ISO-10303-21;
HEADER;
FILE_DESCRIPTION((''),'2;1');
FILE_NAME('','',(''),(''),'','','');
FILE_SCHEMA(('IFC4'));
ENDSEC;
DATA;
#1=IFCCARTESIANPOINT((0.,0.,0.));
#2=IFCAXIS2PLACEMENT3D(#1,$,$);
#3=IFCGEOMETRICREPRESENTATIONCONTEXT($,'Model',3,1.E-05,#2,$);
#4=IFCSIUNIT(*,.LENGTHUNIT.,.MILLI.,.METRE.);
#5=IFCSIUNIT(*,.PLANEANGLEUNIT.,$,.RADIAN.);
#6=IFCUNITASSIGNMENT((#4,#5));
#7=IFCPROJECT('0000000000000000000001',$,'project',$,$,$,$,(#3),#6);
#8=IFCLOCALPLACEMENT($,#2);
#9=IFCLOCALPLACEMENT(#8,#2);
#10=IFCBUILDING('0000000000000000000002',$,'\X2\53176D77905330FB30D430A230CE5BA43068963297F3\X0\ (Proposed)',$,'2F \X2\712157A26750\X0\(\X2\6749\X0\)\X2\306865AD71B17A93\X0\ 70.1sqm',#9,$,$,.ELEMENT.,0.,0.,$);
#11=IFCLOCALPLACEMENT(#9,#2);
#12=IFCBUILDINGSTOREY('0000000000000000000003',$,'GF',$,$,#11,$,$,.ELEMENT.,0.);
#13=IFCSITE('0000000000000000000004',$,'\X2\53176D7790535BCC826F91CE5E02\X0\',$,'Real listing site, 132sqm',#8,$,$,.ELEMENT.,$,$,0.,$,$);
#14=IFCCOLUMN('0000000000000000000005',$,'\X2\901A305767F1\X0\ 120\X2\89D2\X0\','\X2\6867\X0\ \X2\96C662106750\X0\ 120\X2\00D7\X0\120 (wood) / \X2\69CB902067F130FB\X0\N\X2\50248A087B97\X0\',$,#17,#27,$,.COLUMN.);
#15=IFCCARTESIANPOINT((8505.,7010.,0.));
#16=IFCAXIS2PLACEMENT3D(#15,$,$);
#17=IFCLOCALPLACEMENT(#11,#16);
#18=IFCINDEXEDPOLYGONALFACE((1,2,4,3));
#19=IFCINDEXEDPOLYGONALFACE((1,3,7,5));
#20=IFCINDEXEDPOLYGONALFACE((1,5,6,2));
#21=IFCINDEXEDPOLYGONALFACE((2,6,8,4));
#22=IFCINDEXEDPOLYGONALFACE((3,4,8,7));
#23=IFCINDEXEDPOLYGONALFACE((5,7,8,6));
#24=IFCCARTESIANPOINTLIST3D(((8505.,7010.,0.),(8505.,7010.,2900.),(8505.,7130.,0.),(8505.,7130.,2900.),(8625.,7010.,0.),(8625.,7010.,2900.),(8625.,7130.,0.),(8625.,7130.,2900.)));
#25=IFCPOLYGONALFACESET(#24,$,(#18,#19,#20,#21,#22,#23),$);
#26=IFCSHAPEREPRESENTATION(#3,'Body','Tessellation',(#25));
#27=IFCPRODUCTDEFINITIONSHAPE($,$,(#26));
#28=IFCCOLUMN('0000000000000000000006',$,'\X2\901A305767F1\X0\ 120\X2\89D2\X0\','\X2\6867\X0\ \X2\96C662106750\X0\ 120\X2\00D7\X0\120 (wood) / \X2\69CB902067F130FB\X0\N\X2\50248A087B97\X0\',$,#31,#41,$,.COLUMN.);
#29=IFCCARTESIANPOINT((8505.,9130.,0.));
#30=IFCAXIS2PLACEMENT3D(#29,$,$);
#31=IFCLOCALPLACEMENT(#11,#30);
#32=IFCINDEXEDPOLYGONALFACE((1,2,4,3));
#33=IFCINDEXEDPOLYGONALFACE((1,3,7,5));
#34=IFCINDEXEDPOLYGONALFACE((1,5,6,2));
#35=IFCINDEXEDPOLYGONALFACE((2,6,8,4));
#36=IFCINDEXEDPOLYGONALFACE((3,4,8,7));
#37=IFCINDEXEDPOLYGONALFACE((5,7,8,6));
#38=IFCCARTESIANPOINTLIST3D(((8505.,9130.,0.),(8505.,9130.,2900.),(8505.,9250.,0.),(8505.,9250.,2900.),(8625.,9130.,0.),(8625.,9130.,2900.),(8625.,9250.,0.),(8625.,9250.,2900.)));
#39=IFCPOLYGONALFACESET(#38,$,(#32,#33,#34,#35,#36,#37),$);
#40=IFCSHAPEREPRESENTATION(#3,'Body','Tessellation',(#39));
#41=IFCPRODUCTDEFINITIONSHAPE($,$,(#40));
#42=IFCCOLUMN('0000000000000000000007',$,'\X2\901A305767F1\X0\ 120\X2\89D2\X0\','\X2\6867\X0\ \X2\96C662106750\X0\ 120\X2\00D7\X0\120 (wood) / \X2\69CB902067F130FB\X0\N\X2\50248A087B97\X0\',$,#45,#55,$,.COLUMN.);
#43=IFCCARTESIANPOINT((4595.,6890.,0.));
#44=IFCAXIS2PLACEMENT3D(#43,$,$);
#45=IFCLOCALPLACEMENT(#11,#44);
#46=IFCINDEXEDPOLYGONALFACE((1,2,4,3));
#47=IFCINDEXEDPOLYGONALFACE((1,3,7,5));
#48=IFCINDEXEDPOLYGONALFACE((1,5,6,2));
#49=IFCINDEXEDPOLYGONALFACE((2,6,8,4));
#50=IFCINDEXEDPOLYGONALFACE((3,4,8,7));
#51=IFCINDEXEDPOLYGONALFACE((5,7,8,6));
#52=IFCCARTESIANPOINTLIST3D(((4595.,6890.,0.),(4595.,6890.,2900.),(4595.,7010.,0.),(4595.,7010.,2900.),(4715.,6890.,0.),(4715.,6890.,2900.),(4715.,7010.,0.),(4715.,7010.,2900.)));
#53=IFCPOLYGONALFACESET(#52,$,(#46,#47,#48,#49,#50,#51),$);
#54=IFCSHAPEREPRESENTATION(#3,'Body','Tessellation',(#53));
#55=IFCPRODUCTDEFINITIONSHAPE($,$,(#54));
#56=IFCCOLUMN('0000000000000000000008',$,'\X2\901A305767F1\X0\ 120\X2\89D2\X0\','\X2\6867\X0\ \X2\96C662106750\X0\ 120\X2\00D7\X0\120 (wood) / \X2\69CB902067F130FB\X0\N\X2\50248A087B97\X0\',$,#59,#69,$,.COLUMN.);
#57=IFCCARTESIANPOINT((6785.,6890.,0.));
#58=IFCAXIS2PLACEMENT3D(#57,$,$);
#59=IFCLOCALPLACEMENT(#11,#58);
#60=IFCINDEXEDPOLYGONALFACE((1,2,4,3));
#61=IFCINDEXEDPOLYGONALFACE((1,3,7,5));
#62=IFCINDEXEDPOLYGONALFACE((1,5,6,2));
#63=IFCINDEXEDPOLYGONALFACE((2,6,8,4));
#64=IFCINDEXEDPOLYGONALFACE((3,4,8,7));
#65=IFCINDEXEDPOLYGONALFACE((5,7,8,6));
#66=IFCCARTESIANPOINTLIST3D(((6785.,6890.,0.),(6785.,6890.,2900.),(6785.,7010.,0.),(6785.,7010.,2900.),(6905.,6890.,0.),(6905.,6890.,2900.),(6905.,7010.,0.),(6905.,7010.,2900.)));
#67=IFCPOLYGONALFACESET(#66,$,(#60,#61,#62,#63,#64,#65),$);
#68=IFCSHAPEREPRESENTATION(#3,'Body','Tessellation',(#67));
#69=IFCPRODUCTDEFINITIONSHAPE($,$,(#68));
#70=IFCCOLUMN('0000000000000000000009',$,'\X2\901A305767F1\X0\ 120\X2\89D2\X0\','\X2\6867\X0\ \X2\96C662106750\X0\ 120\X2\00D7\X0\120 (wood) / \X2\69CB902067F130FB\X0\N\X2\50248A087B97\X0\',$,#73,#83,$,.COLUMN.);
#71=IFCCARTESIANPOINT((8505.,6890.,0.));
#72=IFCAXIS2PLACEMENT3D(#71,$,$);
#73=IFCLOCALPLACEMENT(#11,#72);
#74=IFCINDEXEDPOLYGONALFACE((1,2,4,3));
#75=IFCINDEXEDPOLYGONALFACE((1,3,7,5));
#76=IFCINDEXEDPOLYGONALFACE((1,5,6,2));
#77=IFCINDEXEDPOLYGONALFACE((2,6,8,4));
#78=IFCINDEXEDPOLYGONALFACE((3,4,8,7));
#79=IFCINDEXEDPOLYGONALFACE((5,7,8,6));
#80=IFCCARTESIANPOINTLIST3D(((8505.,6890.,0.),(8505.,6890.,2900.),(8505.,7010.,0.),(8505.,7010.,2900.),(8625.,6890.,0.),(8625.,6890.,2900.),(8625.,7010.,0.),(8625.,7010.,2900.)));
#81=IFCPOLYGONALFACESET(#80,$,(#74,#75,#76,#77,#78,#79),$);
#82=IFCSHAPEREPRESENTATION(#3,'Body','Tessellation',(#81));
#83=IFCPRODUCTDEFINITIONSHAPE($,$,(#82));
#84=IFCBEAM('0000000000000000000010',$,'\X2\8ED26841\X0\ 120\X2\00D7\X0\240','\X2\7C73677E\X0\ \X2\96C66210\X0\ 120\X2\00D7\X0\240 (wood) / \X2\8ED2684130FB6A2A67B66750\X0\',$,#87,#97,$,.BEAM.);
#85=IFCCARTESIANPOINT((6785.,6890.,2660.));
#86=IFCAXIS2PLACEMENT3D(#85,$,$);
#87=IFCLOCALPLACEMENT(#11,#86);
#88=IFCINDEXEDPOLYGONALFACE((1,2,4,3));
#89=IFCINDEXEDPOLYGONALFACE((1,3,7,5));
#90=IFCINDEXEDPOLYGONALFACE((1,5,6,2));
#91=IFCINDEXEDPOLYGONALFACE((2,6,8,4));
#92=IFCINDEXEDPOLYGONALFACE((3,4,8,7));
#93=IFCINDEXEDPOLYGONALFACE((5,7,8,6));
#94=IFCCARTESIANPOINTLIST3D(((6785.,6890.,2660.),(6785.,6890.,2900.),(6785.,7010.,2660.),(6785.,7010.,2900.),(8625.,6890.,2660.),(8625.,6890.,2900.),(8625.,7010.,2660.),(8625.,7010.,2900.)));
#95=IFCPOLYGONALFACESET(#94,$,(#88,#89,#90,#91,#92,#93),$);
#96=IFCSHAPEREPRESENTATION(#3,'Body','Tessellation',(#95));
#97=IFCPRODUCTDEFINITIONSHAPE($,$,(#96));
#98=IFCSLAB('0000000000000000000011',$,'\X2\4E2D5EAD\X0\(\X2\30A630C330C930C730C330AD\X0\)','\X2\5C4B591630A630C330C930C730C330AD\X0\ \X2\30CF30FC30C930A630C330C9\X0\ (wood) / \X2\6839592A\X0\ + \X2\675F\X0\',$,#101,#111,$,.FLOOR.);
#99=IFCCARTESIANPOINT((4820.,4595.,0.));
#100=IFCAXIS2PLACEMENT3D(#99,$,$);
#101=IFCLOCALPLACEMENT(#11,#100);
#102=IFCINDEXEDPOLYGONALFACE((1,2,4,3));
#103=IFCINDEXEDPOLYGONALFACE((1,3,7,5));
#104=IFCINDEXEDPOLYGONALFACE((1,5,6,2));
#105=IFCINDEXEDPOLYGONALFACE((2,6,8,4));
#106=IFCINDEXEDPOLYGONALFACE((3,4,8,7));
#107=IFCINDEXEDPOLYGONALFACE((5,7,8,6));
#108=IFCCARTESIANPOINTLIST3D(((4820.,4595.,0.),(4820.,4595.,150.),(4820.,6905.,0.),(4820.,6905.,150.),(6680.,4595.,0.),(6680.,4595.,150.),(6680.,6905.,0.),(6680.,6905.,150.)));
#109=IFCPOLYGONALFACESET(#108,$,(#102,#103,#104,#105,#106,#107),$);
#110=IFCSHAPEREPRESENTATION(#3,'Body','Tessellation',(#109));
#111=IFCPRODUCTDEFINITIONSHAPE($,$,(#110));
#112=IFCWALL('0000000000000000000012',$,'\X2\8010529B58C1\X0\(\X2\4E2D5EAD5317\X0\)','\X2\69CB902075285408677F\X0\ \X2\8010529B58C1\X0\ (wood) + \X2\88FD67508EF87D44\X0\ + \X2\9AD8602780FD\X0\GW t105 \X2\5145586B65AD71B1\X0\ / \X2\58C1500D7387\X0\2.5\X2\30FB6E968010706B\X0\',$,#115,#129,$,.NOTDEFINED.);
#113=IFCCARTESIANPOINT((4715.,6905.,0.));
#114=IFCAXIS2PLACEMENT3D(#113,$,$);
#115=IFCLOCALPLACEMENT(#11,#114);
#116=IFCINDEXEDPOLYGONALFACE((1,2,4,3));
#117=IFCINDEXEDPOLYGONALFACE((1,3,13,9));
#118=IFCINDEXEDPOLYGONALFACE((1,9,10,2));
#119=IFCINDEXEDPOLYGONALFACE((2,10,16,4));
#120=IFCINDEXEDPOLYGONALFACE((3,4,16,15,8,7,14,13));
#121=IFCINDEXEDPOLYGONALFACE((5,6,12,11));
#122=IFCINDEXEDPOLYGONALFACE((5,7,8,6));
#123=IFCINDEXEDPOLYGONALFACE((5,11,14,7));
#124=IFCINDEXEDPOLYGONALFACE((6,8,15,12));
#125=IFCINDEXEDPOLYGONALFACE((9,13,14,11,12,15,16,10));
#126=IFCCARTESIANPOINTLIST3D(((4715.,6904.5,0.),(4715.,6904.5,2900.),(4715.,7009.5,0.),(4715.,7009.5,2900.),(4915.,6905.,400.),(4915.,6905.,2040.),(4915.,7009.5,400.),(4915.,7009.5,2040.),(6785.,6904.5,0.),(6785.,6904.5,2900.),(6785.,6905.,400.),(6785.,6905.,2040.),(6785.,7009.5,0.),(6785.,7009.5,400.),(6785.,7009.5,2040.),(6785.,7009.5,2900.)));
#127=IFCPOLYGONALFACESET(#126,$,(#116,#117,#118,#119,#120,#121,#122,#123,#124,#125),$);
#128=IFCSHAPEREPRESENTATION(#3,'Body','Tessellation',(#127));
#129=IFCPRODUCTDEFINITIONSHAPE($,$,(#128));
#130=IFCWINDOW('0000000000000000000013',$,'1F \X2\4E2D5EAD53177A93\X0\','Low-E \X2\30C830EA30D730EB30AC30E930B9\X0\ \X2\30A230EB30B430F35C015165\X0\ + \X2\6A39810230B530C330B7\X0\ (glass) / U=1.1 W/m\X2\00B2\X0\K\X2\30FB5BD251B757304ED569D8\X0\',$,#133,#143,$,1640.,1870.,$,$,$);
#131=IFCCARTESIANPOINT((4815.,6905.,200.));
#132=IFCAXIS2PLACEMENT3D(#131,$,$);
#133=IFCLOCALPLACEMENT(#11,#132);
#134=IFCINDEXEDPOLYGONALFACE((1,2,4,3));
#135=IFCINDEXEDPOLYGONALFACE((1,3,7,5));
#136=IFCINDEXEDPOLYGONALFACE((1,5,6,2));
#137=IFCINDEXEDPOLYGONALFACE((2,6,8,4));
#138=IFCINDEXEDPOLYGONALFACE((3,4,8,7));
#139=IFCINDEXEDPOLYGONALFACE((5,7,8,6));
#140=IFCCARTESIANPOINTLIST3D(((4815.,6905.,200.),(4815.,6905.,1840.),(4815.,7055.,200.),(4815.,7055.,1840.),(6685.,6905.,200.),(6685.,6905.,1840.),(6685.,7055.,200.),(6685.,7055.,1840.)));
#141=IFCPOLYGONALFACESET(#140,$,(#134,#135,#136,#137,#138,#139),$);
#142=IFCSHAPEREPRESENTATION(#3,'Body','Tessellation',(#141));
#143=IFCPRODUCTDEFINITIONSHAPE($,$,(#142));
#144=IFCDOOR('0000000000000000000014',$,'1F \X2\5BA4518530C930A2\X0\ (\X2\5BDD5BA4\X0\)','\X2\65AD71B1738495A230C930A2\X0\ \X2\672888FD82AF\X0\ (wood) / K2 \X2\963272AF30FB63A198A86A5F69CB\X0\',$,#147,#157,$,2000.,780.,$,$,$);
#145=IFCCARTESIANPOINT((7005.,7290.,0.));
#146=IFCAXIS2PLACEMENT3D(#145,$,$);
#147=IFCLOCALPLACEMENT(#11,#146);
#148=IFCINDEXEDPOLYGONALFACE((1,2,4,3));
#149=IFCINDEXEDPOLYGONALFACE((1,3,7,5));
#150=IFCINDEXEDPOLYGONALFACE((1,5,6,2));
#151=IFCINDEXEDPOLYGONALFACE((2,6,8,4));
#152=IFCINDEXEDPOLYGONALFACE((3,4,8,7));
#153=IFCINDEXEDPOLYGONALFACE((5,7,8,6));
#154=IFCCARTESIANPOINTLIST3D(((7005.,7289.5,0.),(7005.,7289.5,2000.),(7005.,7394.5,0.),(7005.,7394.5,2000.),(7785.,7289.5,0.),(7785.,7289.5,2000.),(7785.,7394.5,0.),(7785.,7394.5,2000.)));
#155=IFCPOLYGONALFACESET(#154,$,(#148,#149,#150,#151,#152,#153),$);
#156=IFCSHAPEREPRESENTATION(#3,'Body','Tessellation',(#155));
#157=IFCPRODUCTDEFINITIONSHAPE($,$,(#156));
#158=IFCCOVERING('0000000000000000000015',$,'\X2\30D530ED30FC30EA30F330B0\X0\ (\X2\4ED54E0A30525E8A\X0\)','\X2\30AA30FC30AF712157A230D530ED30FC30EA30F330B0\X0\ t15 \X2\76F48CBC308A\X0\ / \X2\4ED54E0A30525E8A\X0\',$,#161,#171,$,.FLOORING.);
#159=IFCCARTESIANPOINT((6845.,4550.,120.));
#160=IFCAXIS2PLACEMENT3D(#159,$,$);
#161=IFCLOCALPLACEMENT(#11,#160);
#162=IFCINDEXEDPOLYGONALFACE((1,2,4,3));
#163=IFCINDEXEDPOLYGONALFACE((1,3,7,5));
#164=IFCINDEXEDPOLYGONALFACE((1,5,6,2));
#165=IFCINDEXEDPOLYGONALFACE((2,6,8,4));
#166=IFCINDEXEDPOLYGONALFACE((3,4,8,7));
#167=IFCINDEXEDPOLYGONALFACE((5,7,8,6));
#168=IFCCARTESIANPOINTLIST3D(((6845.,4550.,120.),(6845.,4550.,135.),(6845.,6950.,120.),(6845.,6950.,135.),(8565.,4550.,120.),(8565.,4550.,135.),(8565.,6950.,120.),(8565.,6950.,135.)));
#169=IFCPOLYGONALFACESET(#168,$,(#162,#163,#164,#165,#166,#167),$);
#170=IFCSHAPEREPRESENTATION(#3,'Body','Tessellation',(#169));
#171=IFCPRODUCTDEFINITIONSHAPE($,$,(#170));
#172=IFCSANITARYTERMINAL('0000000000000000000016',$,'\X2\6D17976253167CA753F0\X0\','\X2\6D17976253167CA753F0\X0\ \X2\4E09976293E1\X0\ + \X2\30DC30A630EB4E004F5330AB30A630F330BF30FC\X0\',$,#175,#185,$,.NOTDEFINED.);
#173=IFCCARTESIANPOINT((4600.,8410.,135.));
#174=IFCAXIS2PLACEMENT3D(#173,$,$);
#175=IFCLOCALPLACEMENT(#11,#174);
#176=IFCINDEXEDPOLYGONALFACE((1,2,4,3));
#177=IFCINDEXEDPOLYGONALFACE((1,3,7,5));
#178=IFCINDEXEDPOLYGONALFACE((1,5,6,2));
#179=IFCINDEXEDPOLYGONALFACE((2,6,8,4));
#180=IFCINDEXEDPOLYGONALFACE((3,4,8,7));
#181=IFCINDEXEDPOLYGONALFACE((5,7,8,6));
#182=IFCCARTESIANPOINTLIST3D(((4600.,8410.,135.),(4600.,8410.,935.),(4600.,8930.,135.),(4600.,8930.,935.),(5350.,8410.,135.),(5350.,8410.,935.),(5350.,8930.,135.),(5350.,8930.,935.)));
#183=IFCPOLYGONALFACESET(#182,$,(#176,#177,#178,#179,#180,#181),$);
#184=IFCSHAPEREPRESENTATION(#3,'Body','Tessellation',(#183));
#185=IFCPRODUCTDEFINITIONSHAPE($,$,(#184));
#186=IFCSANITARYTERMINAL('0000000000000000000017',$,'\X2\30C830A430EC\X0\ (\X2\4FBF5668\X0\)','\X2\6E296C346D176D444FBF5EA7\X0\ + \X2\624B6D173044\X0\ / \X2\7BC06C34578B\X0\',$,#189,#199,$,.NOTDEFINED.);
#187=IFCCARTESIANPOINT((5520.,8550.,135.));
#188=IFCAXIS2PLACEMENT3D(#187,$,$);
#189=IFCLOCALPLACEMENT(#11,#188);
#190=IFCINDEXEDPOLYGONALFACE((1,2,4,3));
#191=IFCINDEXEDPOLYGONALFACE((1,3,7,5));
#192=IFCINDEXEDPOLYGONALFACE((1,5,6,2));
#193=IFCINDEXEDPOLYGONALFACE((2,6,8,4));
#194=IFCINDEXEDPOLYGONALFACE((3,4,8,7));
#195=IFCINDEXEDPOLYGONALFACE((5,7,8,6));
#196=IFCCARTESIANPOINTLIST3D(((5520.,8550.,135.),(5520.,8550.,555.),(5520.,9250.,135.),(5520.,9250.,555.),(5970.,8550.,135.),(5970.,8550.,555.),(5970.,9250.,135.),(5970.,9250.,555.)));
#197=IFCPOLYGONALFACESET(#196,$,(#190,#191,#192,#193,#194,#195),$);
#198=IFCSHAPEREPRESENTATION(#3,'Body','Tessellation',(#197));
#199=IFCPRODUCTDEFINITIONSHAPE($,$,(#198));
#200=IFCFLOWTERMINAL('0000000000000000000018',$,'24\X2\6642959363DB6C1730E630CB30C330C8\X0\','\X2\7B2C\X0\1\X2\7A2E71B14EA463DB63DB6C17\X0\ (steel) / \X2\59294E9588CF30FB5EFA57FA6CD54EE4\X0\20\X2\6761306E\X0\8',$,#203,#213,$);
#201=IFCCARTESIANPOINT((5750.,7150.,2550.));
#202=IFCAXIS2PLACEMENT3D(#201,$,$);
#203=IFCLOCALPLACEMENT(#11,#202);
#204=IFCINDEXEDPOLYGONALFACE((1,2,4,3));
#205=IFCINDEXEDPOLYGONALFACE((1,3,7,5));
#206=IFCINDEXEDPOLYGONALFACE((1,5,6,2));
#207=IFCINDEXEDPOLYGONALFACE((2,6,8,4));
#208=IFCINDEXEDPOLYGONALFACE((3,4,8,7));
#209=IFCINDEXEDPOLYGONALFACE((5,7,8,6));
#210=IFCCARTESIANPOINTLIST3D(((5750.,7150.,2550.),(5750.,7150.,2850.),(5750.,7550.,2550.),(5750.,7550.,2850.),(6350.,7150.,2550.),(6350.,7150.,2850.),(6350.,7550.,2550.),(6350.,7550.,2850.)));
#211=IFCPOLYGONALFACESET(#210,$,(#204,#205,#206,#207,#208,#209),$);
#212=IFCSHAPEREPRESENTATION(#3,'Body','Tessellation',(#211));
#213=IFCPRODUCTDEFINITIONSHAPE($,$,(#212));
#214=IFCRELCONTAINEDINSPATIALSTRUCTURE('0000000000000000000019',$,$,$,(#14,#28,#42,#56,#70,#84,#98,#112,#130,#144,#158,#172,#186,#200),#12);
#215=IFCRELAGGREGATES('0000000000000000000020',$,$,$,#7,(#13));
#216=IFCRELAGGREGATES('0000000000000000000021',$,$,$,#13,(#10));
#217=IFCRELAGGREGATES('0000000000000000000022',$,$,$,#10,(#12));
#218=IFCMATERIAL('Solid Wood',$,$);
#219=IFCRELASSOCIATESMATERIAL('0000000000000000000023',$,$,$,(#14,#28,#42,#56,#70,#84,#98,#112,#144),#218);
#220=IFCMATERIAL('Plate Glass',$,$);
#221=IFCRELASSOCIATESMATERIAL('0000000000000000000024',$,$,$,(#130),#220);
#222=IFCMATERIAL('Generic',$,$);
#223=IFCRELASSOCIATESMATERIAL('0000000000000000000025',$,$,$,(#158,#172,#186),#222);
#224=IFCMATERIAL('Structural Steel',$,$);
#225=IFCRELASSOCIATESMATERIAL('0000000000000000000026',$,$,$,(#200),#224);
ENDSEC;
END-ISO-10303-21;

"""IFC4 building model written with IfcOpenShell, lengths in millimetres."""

from ifc_helpers import new_model, si_unit, frame, frame_2d, origin, place, context, project, spatial, rectangle, extrude, material, element, fill, save


model = new_model("IFC4")

# Units and contexts
model_context = context("Model", 3, precision=1e-05, world=origin())
ifc_project = project(units=[si_unit("LENGTHUNIT", "METRE", prefix="MILLI"), si_unit("PLANEANGLEUNIT", "RADIAN")], contexts=[model_context])

# Site, building, storey
site_placement = place(None, origin())
site = spatial("IfcSite", under=ifc_project, at=site_placement, Name="北海道富良野市", ObjectType="Real listing site, 132sqm", CompositionType="ELEMENT", RefElevation=0.0)
building_placement = place(site_placement, origin())
building = spatial("IfcBuilding", under=site, at=building_placement, Name="北海道・ピアノ室と防音 (Proposed)", ObjectType="2F 無垢材(杉)と断熱窓 70.1sqm", CompositionType="ELEMENT", ElevationOfRefHeight=0.0, ElevationOfTerrain=0.0)
storey_placement = place(building_placement, origin())
storey = spatial("IfcBuildingStorey", under=building, at=storey_placement, Name="GF", CompositionType="ELEMENT", Elevation=0.0)

# Columns
ifc_material_1 = material(Name="Solid Wood")
column_1_placement = place(storey_placement, frame((8505.0, 7010.0, 0.0)))
element("IfcColumn", 1, at=column_1_placement, inside=storey, material=ifc_material_1, Name="通し柱 120角", Description="桧 集成材 120×120 (wood) / 構造柱・N値計算", PredefinedType="COLUMN", context=model_context, shape_type="SweptSolid", body=[
    extrude(rectangle(XDim=120.0, YDim=120.0, at=frame_2d((60.0, 60.0))), frame((8505.0, 7010.0, 0.0)), (0.0, 0.0, 1.0), 2900.0),
])
column_2_placement = place(storey_placement, frame((8505.0, 9130.0, 0.0)))
element("IfcColumn", 2, at=column_2_placement, inside=storey, material=ifc_material_1, Name="通し柱 120角", Description="桧 集成材 120×120 (wood) / 構造柱・N値計算", PredefinedType="COLUMN", context=model_context, shape_type="SweptSolid", body=[
    extrude(rectangle(XDim=120.0, YDim=120.0, at=frame_2d((60.0, 60.0))), frame((8505.0, 9130.0, 0.0)), (0.0, 0.0, 1.0), 2900.0),
])
column_3_placement = place(storey_placement, frame((4595.0, 6890.0, 0.0)))
element("IfcColumn", 3, at=column_3_placement, inside=storey, material=ifc_material_1, Name="通し柱 120角", Description="桧 集成材 120×120 (wood) / 構造柱・N値計算", PredefinedType="COLUMN", context=model_context, shape_type="SweptSolid", body=[
    extrude(rectangle(XDim=120.0, YDim=120.0, at=frame_2d((60.0, 60.0))), frame((4595.0, 6890.0, 0.0)), (0.0, 0.0, 1.0), 2900.0),
])
column_4_placement = place(storey_placement, frame((6785.0, 6890.0, 0.0)))
element("IfcColumn", 4, at=column_4_placement, inside=storey, material=ifc_material_1, Name="通し柱 120角", Description="桧 集成材 120×120 (wood) / 構造柱・N値計算", PredefinedType="COLUMN", context=model_context, shape_type="SweptSolid", body=[
    extrude(rectangle(XDim=120.0, YDim=120.0, at=frame_2d((60.0, 60.0))), frame((6785.0, 6890.0, 0.0)), (0.0, 0.0, 1.0), 2900.0),
])
column_5_placement = place(storey_placement, frame((8505.0, 6890.0, 0.0)))
element("IfcColumn", 5, at=column_5_placement, inside=storey, material=ifc_material_1, Name="通し柱 120角", Description="桧 集成材 120×120 (wood) / 構造柱・N値計算", PredefinedType="COLUMN", context=model_context, shape_type="SweptSolid", body=[
    extrude(rectangle(XDim=120.0, YDim=120.0, at=frame_2d((60.0, 60.0))), frame((8505.0, 6890.0, 0.0)), (0.0, 0.0, 1.0), 2900.0),
])

# Beam
beam_1_placement = place(storey_placement, frame((6785.0, 6890.0, 2660.0)))
element("IfcBeam", 6, at=beam_1_placement, inside=storey, material=ifc_material_1, Name="軒桁 120×240", Description="米松 集成 120×240 (wood) / 軒桁・横架材", PredefinedType="BEAM", context=model_context, shape_type="SweptSolid", body=[
    extrude(rectangle(XDim=1840.0, YDim=120.0, at=frame_2d((920.0, 60.0))), frame((6785.0, 6890.0, 2660.0)), (0.0, 0.0, 1.0), 240.0),
])

# Slab
slab_placement = place(storey_placement, frame((4820.0, 4595.0, 0.0)))
element("IfcSlab", 7, at=slab_placement, inside=storey, material=ifc_material_1, Name="中庭(ウッドデッキ)", Description="屋外ウッドデッキ ハードウッド (wood) / 根太 + 束", PredefinedType="FLOOR", context=model_context, shape_type="SweptSolid", body=[
    extrude(rectangle(XDim=1860.0, YDim=2310.0, at=frame_2d((930.0, 1155.0))), frame((4820.0, 4595.0, 0.0)), (0.0, 0.0, 1.0), 150.0),
])

# Wall, opening, window
wall_1_placement = place(storey_placement, frame((4715.0, 6905.0, 0.0)))
wall_1 = element("IfcWall", 8, at=wall_1_placement, inside=storey, material=ifc_material_1, Name="耐力壁(中庭北)", Description="構造用合板 耐力壁 (wood) + 製材軸組 + 高性能GW t105 充填断熱 / 壁倍率2.5・準耐火", PredefinedType="NOTDEFINED", context=model_context, shape_type="SweptSolid", body=[
    extrude(rectangle(XDim=2070.0, YDim=105.0, at=frame_2d((1035.0, 52.0))), frame((4715.0, 6905.0, 0.0)), (0.0, 0.0, 1.0), 2900.0),
])
opening_placement = place(storey_placement, frame((4815.0, 6905.0, 200.0)))
opening = element("IfcOpeningElement", 9, at=opening_placement, cuts=wall_1, PredefinedType="NOTDEFINED", context=model_context, shape_type="SweptSolid", body=[
    extrude(rectangle(XDim=1870.0, YDim=150.0, at=frame_2d((935.0, 75.0))), frame((4815.0, 6905.0, 200.0)), (0.0, 0.0, 1.0), 1640.0),
])
ifc_material_2 = material(Name="Plate Glass")
window_placement = place(storey_placement, frame((4815.0, 6905.0, 200.0)))
window = element("IfcWindow", 10, at=window_placement, inside=storey, material=ifc_material_2, Name="1F 中庭北窓", Description="Low-E トリプルガラス アルゴン封入 + 樹脂サッシ (glass) / U=1.1 W/m²K・寒冷地仕様", OverallHeight=1640.0, OverallWidth=1870.0, context=model_context, shape_type="SweptSolid", body=[
    extrude(rectangle(XDim=1870.0, YDim=150.0, at=frame_2d((935.0, 75.0))), frame((4815.0, 6905.0, 200.0)), (0.0, 0.0, 1.0), 1640.0),
])
fill(opening, window)

# Door
door_placement = place(storey_placement, frame((7005.0, 7290.0, 0.0)))
element("IfcDoor", 11, at=door_placement, inside=storey, material=ifc_material_1, Name="1F 室内ドア (寝室)", Description="断熱玄関ドア 木製芯 (wood) / K2 防犯・採風機構", OverallHeight=2000.0, OverallWidth=780.0, context=model_context, shape_type="SweptSolid", body=[
    extrude(rectangle(XDim=780.0, YDim=105.0, at=frame_2d((390.0, 52.0))), frame((7005.0, 7290.0, 0.0)), (0.0, 0.0, 1.0), 2000.0),
])

# Covering
ifc_material_3 = material(Name="Generic")
covering_placement = place(storey_placement, frame((6845.0, 4550.0, 120.0)))
element("IfcCovering", 12, at=covering_placement, inside=storey, material=ifc_material_3, Name="フローリング (仕上げ床)", Description="オーク無垢フローリング t15 直貼り / 仕上げ床", PredefinedType="FLOORING", context=model_context, shape_type="SweptSolid", body=[
    extrude(rectangle(XDim=1720.0, YDim=2400.0, at=frame_2d((860.0, 1200.0))), frame((6845.0, 4550.0, 120.0)), (0.0, 0.0, 1.0), 15.0),
])

# Sanitary terminals
sanitary_terminal_1_placement = place(storey_placement, frame((4600.0, 8410.0, 135.0)))
element("IfcSanitaryTerminal", 13, at=sanitary_terminal_1_placement, inside=storey, material=ifc_material_3, Name="洗面化粧台", Description="洗面化粧台 三面鏡 + ボウル一体カウンター", PredefinedType="NOTDEFINED", context=model_context, shape_type="SweptSolid", body=[
    extrude(rectangle(XDim=750.0, YDim=520.0, at=frame_2d((375.0, 260.0))), frame((4600.0, 8410.0, 135.0)), (0.0, 0.0, 1.0), 800.0),
])
sanitary_terminal_2_placement = place(storey_placement, frame((5520.0, 8550.0, 135.0)))
element("IfcSanitaryTerminal", 14, at=sanitary_terminal_2_placement, inside=storey, material=ifc_material_3, Name="トイレ (便器)", Description="温水洗浄便座 + 手洗い / 節水型", PredefinedType="NOTDEFINED", context=model_context, shape_type="SweptSolid", body=[
    extrude(rectangle(XDim=450.0, YDim=700.0, at=frame_2d((225.0, 350.0))), frame((5520.0, 8550.0, 135.0)), (0.0, 0.0, 1.0), 420.0),
])

# Flow terminal
ifc_material_4 = material(Name="Structural Steel")
flow_terminal_placement = place(storey_placement, frame((5750.0, 7150.0, 2550.0)))
element("IfcFlowTerminal", 15, at=flow_terminal_placement, inside=storey, material=ifc_material_4, Name="24時間換気ユニット", Description="第1種熱交換換気 (steel) / 天井裏・建基法令20条の8", context=model_context, shape_type="SweptSolid", body=[
    extrude(rectangle(XDim=600.0, YDim=400.0, at=frame_2d((300.0, 200.0))), frame((5750.0, 7150.0, 2550.0)), (0.0, 0.0, 1.0), 300.0),
])

save(model, "model.ifc")
